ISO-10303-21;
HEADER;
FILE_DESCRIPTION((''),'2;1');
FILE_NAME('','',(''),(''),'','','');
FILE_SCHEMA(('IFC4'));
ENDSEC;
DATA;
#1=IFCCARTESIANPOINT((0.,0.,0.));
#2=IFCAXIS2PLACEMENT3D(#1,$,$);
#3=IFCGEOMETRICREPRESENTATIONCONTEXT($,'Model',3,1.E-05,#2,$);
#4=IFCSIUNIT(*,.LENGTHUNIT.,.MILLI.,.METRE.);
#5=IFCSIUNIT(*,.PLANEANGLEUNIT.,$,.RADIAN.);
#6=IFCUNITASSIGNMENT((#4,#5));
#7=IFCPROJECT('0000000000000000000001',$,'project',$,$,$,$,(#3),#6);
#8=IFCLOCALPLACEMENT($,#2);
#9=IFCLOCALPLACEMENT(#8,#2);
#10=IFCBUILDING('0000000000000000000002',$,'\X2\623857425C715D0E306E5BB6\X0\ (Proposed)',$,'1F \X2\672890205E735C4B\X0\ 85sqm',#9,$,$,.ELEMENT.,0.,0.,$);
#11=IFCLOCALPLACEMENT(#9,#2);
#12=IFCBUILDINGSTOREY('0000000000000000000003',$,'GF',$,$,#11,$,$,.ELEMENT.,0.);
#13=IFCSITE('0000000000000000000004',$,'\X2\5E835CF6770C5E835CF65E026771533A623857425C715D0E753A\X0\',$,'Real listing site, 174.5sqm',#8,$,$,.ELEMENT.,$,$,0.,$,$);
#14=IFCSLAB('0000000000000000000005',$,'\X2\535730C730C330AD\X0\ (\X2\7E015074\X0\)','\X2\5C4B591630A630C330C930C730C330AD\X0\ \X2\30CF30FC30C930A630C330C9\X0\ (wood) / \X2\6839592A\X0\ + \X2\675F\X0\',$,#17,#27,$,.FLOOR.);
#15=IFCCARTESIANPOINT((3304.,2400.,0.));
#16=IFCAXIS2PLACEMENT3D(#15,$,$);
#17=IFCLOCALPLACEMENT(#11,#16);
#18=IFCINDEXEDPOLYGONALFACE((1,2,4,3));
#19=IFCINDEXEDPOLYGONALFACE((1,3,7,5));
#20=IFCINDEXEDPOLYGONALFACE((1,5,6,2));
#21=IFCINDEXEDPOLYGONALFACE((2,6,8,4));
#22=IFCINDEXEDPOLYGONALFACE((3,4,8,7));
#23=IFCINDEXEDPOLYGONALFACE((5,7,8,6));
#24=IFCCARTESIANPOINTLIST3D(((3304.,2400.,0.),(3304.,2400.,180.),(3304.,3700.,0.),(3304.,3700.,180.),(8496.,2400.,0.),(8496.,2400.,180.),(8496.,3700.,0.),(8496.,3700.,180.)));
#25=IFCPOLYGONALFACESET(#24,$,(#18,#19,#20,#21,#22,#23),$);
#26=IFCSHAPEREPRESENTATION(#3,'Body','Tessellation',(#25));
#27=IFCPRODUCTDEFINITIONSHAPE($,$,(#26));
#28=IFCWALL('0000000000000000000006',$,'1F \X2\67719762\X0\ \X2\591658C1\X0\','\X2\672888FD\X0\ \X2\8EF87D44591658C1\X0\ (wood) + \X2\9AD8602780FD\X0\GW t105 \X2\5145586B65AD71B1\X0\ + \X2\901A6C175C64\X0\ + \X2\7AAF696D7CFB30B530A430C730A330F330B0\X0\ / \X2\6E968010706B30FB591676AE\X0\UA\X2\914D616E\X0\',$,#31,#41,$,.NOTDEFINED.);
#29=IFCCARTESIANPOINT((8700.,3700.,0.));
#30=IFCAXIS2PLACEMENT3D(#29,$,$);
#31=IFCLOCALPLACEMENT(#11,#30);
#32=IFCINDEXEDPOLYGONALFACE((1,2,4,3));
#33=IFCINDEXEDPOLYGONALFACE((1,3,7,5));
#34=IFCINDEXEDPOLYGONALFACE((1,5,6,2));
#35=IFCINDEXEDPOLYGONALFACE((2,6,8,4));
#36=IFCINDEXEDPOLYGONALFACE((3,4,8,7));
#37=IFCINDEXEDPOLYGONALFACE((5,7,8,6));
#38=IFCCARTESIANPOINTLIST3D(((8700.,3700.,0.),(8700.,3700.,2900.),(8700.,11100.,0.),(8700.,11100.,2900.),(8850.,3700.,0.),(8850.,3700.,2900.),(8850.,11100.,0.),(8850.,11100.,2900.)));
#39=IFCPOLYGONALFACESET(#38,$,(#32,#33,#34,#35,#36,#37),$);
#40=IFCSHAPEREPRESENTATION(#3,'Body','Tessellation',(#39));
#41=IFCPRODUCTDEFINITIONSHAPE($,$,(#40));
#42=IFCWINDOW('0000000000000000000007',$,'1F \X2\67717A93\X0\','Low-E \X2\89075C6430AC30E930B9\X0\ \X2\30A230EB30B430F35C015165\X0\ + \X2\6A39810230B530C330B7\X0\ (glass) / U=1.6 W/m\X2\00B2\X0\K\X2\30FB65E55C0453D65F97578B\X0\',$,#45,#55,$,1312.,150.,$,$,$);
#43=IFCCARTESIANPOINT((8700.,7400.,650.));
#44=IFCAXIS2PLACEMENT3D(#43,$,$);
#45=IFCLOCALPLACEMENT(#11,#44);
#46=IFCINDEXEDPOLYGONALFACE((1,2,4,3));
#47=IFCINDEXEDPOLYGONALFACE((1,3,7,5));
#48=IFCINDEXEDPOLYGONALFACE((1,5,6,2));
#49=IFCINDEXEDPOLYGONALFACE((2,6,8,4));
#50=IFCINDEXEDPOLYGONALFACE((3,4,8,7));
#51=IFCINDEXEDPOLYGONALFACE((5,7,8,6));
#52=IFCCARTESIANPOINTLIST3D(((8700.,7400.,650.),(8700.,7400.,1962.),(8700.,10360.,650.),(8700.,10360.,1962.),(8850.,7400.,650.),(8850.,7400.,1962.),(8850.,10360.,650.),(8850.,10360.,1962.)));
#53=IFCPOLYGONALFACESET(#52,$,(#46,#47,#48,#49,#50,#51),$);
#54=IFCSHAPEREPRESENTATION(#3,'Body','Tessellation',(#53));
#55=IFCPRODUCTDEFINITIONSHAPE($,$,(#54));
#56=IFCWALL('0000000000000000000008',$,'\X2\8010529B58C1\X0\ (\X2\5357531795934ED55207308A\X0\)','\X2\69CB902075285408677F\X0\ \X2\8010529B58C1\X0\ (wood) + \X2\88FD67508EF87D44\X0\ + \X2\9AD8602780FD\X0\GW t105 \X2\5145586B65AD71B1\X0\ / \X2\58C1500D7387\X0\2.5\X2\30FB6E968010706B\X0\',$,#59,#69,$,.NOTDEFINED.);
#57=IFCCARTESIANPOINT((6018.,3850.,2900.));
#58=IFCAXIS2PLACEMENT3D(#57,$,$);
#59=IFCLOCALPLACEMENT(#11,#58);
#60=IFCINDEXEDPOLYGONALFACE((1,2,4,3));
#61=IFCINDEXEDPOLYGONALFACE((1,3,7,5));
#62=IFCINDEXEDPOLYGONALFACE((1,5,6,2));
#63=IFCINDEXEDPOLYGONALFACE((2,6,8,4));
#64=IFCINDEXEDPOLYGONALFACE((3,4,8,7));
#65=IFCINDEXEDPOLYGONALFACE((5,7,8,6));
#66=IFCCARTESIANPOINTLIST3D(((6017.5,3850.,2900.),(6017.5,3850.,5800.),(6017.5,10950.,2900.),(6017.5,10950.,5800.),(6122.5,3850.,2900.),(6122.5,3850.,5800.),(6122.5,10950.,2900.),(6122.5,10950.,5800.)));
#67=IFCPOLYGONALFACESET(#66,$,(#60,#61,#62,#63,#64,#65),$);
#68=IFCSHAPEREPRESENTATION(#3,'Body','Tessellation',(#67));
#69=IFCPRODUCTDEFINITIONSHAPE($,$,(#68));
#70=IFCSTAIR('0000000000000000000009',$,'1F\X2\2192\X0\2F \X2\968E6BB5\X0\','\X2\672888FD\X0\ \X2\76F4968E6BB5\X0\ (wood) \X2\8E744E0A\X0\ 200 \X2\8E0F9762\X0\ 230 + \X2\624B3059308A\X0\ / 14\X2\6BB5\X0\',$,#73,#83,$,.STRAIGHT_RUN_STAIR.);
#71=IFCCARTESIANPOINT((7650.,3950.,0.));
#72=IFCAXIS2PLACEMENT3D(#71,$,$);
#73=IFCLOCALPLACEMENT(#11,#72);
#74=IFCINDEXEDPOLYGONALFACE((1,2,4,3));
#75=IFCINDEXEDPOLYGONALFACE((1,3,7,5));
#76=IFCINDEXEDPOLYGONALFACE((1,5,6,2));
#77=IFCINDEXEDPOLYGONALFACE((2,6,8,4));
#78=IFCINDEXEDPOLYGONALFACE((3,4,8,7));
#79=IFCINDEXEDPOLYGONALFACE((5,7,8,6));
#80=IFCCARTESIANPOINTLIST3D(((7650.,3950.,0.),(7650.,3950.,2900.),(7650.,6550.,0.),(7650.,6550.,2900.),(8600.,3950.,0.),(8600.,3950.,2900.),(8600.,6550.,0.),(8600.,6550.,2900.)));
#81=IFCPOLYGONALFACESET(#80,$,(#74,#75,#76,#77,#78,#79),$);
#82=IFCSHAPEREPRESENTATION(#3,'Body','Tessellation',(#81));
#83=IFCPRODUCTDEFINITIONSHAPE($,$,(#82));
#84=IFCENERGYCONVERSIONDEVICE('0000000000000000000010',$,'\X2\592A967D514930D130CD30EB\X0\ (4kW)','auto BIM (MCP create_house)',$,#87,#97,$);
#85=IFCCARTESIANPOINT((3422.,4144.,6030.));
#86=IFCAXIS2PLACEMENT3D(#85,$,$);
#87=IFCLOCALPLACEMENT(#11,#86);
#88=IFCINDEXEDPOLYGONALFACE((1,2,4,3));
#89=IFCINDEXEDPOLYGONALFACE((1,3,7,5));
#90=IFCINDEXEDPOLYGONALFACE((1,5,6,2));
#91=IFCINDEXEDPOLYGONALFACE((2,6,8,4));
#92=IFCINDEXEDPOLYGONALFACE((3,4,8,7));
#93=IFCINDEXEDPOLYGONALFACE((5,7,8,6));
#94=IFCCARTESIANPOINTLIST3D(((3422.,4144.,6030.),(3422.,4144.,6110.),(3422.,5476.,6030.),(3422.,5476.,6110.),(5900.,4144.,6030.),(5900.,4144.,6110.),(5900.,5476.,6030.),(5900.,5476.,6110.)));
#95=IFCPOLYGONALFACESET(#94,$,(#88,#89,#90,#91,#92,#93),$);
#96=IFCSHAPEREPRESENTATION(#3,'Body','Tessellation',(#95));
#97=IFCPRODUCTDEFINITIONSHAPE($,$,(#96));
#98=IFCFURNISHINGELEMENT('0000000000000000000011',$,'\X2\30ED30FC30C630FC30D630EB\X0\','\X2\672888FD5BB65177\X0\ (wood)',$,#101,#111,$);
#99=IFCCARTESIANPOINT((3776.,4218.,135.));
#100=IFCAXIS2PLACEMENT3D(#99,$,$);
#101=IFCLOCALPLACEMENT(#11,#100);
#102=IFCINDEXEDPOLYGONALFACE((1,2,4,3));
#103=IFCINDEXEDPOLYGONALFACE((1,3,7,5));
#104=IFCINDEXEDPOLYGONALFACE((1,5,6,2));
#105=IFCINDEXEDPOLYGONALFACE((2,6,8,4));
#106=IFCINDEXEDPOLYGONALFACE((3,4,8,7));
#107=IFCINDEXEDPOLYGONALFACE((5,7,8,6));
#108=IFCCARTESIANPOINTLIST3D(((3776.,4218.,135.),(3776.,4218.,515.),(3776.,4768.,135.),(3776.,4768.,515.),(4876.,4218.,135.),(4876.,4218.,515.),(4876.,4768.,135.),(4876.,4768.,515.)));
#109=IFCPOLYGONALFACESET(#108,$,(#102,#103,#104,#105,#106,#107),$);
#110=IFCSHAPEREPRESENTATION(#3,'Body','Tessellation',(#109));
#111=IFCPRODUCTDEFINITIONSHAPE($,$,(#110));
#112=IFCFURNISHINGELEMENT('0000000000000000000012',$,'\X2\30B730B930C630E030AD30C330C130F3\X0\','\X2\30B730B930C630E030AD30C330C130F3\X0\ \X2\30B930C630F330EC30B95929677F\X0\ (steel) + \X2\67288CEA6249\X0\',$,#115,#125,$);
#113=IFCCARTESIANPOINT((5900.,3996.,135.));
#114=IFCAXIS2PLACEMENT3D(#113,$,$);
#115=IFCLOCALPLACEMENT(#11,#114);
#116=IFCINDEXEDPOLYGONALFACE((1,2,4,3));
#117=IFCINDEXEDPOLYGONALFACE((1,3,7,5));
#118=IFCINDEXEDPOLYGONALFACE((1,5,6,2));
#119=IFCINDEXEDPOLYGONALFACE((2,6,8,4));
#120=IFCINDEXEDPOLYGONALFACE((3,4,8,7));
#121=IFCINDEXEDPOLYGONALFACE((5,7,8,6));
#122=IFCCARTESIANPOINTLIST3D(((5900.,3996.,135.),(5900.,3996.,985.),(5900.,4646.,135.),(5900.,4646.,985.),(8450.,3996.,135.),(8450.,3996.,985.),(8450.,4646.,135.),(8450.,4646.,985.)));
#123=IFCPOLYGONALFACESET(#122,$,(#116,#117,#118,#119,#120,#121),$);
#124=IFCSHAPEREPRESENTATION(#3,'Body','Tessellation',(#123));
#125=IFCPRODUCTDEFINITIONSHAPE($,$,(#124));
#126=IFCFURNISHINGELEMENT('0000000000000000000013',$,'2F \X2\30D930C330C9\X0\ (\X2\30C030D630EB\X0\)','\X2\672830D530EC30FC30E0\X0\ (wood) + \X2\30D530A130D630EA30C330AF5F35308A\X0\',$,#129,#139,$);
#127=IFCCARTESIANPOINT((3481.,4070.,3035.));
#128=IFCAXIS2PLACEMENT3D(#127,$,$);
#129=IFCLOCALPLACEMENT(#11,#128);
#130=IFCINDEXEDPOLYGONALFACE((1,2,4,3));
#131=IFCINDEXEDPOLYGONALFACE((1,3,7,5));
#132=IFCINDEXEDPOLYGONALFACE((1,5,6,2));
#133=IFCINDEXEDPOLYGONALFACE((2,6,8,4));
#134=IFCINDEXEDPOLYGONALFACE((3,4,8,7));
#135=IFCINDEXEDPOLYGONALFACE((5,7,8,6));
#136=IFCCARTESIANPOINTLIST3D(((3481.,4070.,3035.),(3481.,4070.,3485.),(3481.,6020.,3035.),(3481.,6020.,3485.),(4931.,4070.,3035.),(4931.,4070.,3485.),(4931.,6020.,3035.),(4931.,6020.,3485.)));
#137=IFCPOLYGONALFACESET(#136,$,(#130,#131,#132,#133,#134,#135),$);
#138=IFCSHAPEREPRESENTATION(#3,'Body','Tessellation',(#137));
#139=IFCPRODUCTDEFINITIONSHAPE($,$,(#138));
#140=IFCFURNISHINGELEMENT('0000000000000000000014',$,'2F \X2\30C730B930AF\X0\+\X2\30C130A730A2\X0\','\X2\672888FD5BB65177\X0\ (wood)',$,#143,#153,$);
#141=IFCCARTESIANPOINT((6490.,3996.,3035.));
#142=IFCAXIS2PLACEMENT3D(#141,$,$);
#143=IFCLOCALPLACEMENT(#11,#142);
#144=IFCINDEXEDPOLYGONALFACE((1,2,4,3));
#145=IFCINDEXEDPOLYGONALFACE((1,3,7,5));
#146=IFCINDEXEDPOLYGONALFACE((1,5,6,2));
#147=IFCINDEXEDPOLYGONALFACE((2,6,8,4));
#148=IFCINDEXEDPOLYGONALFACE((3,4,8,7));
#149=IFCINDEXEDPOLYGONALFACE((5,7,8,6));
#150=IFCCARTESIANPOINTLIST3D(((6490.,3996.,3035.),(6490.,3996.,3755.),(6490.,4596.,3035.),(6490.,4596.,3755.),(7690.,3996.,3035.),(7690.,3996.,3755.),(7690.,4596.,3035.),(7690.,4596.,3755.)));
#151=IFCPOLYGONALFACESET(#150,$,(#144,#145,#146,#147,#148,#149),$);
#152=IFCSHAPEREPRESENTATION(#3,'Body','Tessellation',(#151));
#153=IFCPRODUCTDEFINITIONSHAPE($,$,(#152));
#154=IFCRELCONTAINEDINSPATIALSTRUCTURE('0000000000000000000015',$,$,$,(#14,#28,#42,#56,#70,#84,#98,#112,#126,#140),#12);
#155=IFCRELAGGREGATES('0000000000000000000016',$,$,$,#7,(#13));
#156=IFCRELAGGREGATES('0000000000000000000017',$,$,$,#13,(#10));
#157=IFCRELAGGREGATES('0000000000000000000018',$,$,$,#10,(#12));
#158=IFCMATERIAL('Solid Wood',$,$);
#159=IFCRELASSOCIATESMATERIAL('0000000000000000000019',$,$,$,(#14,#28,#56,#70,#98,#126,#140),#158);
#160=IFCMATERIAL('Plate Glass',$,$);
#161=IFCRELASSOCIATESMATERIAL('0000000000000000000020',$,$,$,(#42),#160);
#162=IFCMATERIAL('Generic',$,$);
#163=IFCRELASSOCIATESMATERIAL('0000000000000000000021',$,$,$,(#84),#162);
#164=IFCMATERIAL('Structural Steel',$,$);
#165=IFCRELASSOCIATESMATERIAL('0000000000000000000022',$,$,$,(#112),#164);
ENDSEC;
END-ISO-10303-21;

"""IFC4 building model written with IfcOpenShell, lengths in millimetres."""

from ifc_helpers import new_model, si_unit, frame, frame_2d, origin, place, context, project, spatial, rectangle, extrude, material, element, fill, save


model = new_model("IFC4")

# Units and contexts
model_context = context("Model", 3, precision=1e-05, world=origin())
ifc_project = project(units=[si_unit("LENGTHUNIT", "METRE", prefix="MILLI"), si_unit("PLANEANGLEUNIT", "RADIAN")], contexts=[model_context])

# Site, building, storey
site_placement = place(None, origin())
site = spatial("IfcSite", under=ifc_project, at=site_placement, Name="広島県広島市東区戸坂山崎町", ObjectType="Real listing site, 174.5sqm", CompositionType="ELEMENT", RefElevation=0.0)
building_placement = place(site_placement, origin())
building = spatial("IfcBuilding", under=site, at=building_placement, Name="戸坂山崎の家 (Proposed)", ObjectType="1F 木造平屋 85sqm", CompositionType="ELEMENT", ElevationOfRefHeight=0.0, ElevationOfTerrain=0.0)
storey_placement = place(building_placement, origin())
storey = spatial("IfcBuildingStorey", under=building, at=storey_placement, Name="GF", CompositionType="ELEMENT", Elevation=0.0)

# Slab
ifc_material_1 = material(Name="Solid Wood")
slab_placement = place(storey_placement, frame((3304.0, 2400.0, 0.0)))
element("IfcSlab", 1, at=slab_placement, inside=storey, material=ifc_material_1, Name="南デッキ (縁側)", Description="屋外ウッドデッキ ハードウッド (wood) / 根太 + 束", PredefinedType="FLOOR", context=model_context, shape_type="SweptSolid", body=[
    extrude(rectangle(XDim=5192.0, YDim=1300.0, at=frame_2d((2596.0, 650.0))), frame((3304.0, 2400.0, 0.0)), (0.0, 0.0, 1.0), 180.0),
])

# Wall, opening, window
wall_1_placement = place(storey_placement, frame((8700.0, 3700.0, 0.0)))
wall_1 = element("IfcWall", 2, at=wall_1_placement, inside=storey, material=ifc_material_1, Name="1F 東面 外壁", Description="木製 軸組外壁 (wood) + 高性能GW t105 充填断熱 + 通気層 + 窯業系サイディング / 準耐火・外皮UA配慮", PredefinedType="NOTDEFINED", context=model_context, shape_type="SweptSolid", body=[
    extrude(rectangle(XDim=150.0, YDim=7400.0, at=frame_2d((75.0, 3700.0))), frame((8700.0, 3700.0, 0.0)), (0.0, 0.0, 1.0), 2900.0),
])
opening_1_placement = place(storey_placement, frame((8700.0, 7400.0, 650.0)))
opening_1 = element("IfcOpeningElement", 3, at=opening_1_placement, cuts=wall_1, PredefinedType="NOTDEFINED", context=model_context, shape_type="SweptSolid", body=[
    extrude(rectangle(XDim=150.0, YDim=2960.0, at=frame_2d((75.0, 1480.0))), frame((8700.0, 7400.0, 650.0)), (0.0, 0.0, 1.0), 1312.0),
])
ifc_material_2 = material(Name="Plate Glass")
window_1_placement = place(storey_placement, frame((8700.0, 7400.0, 650.0)))
window_1 = element("IfcWindow", 4, at=window_1_placement, inside=storey, material=ifc_material_2, Name="1F 東窓", Description="Low-E 複層ガラス アルゴン封入 + 樹脂サッシ (glass) / U=1.6 W/m²K・日射取得型", OverallHeight=1312.0, OverallWidth=150.0, context=model_context, shape_type="SweptSolid", body=[
    extrude(rectangle(XDim=150.0, YDim=2960.0, at=frame_2d((75.0, 1480.0))), frame((8700.0, 7400.0, 650.0)), (0.0, 0.0, 1.0), 1312.0),
])
fill(opening_1, window_1)

# Wall
wall_2_placement = place(storey_placement, frame((6018.0, 3850.0, 2900.0)))
element("IfcWall", 5, at=wall_2_placement, inside=storey, material=ifc_material_1, Name="耐力壁 (南北間仕切り)", Description="構造用合板 耐力壁 (wood) + 製材軸組 + 高性能GW t105 充填断熱 / 壁倍率2.5・準耐火", PredefinedType="NOTDEFINED", context=model_context, shape_type="SweptSolid", body=[
    extrude(rectangle(XDim=105.0, YDim=7100.0, at=frame_2d((52.0, 3550.0))), frame((6018.0, 3850.0, 2900.0)), (0.0, 0.0, 1.0), 2900.0),
])

# Stair
stair_placement = place(storey_placement, frame((7650.0, 3950.0, 0.0)))
element("IfcStair", 6, at=stair_placement, inside=storey, material=ifc_material_1, Name="1F→2F 階段", Description="木製 直階段 (wood) 蹴上 200 踏面 230 + 手すり / 14段", PredefinedType="STRAIGHT_RUN_STAIR", context=model_context, shape_type="SweptSolid", body=[
    extrude(rectangle(XDim=950.0, YDim=2600.0, at=frame_2d((475.0, 1300.0))), frame((7650.0, 3950.0, 0.0)), (0.0, 0.0, 1.0), 2900.0),
])

# Energy conversion device
ifc_material_3 = material(Name="Generic")
energy_conversion_device_placement = place(storey_placement, frame((3422.0, 4144.0, 6030.0)))
element("IfcEnergyConversionDevice", 7, at=energy_conversion_device_placement, inside=storey, material=ifc_material_3, Name="太陽光パネル (4kW)", Description="auto BIM (MCP create_house)", context=model_context, shape_type="SweptSolid", body=[
    extrude(rectangle(XDim=2478.0, YDim=1332.0, at=frame_2d((1239.0, 666.0))), frame((3422.0, 4144.0, 6030.0)), (0.0, 0.0, 1.0), 80.0),
])

# Furnishing elements
furnishing_1_placement = place(storey_placement, frame((3776.0, 4218.0, 135.0)))
element("IfcFurnishingElement", 8, at=furnishing_1_placement, inside=storey, material=ifc_material_1, Name="ローテーブル", Description="木製家具 (wood)", context=model_context, shape_type="SweptSolid", body=[
    extrude(rectangle(XDim=1100.0, YDim=550.0, at=frame_2d((550.0, 275.0))), frame((3776.0, 4218.0, 135.0)), (0.0, 0.0, 1.0), 380.0),
])
ifc_material_4 = material(Name="Structural Steel")
furnishing_2_placement = place(storey_placement, frame((5900.0, 3996.0, 135.0)))
element("IfcFurnishingElement", 9, at=furnishing_2_placement, inside=storey, material=ifc_material_4, Name="システムキッチン", Description="システムキッチン ステンレス天板 (steel) + 木質扉", context=model_context, shape_type="SweptSolid", body=[
    extrude(rectangle(XDim=2550.0, YDim=650.0, at=frame_2d((1275.0, 325.0))), frame((5900.0, 3996.0, 135.0)), (0.0, 0.0, 1.0), 850.0),
])
furnishing_3_placement = place(storey_placement, frame((3481.0, 4070.0, 3035.0)))
element("IfcFurnishingElement", 10, at=furnishing_3_placement, inside=storey, material=ifc_material_1, Name="2F ベッド (ダブル)", Description="木フレーム (wood) + ファブリック張り", context=model_context, shape_type="SweptSolid", body=[
    extrude(rectangle(XDim=1450.0, YDim=1950.0, at=frame_2d((725.0, 975.0))), frame((3481.0, 4070.0, 3035.0)), (0.0, 0.0, 1.0), 450.0),
])
furnishing_4_placement = place(storey_placement, frame((6490.0, 3996.0, 3035.0)))
element("IfcFurnishingElement", 11, at=furnishing_4_placement, inside=storey, material=ifc_material_1, Name="2F デスク+チェア", Description="木製家具 (wood)", context=model_context, shape_type="SweptSolid", body=[
    extrude(rectangle(XDim=1200.0, YDim=600.0, at=frame_2d((600.0, 300.0))), frame((6490.0, 3996.0, 3035.0)), (0.0, 0.0, 1.0), 720.0),
])

save(model, "model.ifc")
